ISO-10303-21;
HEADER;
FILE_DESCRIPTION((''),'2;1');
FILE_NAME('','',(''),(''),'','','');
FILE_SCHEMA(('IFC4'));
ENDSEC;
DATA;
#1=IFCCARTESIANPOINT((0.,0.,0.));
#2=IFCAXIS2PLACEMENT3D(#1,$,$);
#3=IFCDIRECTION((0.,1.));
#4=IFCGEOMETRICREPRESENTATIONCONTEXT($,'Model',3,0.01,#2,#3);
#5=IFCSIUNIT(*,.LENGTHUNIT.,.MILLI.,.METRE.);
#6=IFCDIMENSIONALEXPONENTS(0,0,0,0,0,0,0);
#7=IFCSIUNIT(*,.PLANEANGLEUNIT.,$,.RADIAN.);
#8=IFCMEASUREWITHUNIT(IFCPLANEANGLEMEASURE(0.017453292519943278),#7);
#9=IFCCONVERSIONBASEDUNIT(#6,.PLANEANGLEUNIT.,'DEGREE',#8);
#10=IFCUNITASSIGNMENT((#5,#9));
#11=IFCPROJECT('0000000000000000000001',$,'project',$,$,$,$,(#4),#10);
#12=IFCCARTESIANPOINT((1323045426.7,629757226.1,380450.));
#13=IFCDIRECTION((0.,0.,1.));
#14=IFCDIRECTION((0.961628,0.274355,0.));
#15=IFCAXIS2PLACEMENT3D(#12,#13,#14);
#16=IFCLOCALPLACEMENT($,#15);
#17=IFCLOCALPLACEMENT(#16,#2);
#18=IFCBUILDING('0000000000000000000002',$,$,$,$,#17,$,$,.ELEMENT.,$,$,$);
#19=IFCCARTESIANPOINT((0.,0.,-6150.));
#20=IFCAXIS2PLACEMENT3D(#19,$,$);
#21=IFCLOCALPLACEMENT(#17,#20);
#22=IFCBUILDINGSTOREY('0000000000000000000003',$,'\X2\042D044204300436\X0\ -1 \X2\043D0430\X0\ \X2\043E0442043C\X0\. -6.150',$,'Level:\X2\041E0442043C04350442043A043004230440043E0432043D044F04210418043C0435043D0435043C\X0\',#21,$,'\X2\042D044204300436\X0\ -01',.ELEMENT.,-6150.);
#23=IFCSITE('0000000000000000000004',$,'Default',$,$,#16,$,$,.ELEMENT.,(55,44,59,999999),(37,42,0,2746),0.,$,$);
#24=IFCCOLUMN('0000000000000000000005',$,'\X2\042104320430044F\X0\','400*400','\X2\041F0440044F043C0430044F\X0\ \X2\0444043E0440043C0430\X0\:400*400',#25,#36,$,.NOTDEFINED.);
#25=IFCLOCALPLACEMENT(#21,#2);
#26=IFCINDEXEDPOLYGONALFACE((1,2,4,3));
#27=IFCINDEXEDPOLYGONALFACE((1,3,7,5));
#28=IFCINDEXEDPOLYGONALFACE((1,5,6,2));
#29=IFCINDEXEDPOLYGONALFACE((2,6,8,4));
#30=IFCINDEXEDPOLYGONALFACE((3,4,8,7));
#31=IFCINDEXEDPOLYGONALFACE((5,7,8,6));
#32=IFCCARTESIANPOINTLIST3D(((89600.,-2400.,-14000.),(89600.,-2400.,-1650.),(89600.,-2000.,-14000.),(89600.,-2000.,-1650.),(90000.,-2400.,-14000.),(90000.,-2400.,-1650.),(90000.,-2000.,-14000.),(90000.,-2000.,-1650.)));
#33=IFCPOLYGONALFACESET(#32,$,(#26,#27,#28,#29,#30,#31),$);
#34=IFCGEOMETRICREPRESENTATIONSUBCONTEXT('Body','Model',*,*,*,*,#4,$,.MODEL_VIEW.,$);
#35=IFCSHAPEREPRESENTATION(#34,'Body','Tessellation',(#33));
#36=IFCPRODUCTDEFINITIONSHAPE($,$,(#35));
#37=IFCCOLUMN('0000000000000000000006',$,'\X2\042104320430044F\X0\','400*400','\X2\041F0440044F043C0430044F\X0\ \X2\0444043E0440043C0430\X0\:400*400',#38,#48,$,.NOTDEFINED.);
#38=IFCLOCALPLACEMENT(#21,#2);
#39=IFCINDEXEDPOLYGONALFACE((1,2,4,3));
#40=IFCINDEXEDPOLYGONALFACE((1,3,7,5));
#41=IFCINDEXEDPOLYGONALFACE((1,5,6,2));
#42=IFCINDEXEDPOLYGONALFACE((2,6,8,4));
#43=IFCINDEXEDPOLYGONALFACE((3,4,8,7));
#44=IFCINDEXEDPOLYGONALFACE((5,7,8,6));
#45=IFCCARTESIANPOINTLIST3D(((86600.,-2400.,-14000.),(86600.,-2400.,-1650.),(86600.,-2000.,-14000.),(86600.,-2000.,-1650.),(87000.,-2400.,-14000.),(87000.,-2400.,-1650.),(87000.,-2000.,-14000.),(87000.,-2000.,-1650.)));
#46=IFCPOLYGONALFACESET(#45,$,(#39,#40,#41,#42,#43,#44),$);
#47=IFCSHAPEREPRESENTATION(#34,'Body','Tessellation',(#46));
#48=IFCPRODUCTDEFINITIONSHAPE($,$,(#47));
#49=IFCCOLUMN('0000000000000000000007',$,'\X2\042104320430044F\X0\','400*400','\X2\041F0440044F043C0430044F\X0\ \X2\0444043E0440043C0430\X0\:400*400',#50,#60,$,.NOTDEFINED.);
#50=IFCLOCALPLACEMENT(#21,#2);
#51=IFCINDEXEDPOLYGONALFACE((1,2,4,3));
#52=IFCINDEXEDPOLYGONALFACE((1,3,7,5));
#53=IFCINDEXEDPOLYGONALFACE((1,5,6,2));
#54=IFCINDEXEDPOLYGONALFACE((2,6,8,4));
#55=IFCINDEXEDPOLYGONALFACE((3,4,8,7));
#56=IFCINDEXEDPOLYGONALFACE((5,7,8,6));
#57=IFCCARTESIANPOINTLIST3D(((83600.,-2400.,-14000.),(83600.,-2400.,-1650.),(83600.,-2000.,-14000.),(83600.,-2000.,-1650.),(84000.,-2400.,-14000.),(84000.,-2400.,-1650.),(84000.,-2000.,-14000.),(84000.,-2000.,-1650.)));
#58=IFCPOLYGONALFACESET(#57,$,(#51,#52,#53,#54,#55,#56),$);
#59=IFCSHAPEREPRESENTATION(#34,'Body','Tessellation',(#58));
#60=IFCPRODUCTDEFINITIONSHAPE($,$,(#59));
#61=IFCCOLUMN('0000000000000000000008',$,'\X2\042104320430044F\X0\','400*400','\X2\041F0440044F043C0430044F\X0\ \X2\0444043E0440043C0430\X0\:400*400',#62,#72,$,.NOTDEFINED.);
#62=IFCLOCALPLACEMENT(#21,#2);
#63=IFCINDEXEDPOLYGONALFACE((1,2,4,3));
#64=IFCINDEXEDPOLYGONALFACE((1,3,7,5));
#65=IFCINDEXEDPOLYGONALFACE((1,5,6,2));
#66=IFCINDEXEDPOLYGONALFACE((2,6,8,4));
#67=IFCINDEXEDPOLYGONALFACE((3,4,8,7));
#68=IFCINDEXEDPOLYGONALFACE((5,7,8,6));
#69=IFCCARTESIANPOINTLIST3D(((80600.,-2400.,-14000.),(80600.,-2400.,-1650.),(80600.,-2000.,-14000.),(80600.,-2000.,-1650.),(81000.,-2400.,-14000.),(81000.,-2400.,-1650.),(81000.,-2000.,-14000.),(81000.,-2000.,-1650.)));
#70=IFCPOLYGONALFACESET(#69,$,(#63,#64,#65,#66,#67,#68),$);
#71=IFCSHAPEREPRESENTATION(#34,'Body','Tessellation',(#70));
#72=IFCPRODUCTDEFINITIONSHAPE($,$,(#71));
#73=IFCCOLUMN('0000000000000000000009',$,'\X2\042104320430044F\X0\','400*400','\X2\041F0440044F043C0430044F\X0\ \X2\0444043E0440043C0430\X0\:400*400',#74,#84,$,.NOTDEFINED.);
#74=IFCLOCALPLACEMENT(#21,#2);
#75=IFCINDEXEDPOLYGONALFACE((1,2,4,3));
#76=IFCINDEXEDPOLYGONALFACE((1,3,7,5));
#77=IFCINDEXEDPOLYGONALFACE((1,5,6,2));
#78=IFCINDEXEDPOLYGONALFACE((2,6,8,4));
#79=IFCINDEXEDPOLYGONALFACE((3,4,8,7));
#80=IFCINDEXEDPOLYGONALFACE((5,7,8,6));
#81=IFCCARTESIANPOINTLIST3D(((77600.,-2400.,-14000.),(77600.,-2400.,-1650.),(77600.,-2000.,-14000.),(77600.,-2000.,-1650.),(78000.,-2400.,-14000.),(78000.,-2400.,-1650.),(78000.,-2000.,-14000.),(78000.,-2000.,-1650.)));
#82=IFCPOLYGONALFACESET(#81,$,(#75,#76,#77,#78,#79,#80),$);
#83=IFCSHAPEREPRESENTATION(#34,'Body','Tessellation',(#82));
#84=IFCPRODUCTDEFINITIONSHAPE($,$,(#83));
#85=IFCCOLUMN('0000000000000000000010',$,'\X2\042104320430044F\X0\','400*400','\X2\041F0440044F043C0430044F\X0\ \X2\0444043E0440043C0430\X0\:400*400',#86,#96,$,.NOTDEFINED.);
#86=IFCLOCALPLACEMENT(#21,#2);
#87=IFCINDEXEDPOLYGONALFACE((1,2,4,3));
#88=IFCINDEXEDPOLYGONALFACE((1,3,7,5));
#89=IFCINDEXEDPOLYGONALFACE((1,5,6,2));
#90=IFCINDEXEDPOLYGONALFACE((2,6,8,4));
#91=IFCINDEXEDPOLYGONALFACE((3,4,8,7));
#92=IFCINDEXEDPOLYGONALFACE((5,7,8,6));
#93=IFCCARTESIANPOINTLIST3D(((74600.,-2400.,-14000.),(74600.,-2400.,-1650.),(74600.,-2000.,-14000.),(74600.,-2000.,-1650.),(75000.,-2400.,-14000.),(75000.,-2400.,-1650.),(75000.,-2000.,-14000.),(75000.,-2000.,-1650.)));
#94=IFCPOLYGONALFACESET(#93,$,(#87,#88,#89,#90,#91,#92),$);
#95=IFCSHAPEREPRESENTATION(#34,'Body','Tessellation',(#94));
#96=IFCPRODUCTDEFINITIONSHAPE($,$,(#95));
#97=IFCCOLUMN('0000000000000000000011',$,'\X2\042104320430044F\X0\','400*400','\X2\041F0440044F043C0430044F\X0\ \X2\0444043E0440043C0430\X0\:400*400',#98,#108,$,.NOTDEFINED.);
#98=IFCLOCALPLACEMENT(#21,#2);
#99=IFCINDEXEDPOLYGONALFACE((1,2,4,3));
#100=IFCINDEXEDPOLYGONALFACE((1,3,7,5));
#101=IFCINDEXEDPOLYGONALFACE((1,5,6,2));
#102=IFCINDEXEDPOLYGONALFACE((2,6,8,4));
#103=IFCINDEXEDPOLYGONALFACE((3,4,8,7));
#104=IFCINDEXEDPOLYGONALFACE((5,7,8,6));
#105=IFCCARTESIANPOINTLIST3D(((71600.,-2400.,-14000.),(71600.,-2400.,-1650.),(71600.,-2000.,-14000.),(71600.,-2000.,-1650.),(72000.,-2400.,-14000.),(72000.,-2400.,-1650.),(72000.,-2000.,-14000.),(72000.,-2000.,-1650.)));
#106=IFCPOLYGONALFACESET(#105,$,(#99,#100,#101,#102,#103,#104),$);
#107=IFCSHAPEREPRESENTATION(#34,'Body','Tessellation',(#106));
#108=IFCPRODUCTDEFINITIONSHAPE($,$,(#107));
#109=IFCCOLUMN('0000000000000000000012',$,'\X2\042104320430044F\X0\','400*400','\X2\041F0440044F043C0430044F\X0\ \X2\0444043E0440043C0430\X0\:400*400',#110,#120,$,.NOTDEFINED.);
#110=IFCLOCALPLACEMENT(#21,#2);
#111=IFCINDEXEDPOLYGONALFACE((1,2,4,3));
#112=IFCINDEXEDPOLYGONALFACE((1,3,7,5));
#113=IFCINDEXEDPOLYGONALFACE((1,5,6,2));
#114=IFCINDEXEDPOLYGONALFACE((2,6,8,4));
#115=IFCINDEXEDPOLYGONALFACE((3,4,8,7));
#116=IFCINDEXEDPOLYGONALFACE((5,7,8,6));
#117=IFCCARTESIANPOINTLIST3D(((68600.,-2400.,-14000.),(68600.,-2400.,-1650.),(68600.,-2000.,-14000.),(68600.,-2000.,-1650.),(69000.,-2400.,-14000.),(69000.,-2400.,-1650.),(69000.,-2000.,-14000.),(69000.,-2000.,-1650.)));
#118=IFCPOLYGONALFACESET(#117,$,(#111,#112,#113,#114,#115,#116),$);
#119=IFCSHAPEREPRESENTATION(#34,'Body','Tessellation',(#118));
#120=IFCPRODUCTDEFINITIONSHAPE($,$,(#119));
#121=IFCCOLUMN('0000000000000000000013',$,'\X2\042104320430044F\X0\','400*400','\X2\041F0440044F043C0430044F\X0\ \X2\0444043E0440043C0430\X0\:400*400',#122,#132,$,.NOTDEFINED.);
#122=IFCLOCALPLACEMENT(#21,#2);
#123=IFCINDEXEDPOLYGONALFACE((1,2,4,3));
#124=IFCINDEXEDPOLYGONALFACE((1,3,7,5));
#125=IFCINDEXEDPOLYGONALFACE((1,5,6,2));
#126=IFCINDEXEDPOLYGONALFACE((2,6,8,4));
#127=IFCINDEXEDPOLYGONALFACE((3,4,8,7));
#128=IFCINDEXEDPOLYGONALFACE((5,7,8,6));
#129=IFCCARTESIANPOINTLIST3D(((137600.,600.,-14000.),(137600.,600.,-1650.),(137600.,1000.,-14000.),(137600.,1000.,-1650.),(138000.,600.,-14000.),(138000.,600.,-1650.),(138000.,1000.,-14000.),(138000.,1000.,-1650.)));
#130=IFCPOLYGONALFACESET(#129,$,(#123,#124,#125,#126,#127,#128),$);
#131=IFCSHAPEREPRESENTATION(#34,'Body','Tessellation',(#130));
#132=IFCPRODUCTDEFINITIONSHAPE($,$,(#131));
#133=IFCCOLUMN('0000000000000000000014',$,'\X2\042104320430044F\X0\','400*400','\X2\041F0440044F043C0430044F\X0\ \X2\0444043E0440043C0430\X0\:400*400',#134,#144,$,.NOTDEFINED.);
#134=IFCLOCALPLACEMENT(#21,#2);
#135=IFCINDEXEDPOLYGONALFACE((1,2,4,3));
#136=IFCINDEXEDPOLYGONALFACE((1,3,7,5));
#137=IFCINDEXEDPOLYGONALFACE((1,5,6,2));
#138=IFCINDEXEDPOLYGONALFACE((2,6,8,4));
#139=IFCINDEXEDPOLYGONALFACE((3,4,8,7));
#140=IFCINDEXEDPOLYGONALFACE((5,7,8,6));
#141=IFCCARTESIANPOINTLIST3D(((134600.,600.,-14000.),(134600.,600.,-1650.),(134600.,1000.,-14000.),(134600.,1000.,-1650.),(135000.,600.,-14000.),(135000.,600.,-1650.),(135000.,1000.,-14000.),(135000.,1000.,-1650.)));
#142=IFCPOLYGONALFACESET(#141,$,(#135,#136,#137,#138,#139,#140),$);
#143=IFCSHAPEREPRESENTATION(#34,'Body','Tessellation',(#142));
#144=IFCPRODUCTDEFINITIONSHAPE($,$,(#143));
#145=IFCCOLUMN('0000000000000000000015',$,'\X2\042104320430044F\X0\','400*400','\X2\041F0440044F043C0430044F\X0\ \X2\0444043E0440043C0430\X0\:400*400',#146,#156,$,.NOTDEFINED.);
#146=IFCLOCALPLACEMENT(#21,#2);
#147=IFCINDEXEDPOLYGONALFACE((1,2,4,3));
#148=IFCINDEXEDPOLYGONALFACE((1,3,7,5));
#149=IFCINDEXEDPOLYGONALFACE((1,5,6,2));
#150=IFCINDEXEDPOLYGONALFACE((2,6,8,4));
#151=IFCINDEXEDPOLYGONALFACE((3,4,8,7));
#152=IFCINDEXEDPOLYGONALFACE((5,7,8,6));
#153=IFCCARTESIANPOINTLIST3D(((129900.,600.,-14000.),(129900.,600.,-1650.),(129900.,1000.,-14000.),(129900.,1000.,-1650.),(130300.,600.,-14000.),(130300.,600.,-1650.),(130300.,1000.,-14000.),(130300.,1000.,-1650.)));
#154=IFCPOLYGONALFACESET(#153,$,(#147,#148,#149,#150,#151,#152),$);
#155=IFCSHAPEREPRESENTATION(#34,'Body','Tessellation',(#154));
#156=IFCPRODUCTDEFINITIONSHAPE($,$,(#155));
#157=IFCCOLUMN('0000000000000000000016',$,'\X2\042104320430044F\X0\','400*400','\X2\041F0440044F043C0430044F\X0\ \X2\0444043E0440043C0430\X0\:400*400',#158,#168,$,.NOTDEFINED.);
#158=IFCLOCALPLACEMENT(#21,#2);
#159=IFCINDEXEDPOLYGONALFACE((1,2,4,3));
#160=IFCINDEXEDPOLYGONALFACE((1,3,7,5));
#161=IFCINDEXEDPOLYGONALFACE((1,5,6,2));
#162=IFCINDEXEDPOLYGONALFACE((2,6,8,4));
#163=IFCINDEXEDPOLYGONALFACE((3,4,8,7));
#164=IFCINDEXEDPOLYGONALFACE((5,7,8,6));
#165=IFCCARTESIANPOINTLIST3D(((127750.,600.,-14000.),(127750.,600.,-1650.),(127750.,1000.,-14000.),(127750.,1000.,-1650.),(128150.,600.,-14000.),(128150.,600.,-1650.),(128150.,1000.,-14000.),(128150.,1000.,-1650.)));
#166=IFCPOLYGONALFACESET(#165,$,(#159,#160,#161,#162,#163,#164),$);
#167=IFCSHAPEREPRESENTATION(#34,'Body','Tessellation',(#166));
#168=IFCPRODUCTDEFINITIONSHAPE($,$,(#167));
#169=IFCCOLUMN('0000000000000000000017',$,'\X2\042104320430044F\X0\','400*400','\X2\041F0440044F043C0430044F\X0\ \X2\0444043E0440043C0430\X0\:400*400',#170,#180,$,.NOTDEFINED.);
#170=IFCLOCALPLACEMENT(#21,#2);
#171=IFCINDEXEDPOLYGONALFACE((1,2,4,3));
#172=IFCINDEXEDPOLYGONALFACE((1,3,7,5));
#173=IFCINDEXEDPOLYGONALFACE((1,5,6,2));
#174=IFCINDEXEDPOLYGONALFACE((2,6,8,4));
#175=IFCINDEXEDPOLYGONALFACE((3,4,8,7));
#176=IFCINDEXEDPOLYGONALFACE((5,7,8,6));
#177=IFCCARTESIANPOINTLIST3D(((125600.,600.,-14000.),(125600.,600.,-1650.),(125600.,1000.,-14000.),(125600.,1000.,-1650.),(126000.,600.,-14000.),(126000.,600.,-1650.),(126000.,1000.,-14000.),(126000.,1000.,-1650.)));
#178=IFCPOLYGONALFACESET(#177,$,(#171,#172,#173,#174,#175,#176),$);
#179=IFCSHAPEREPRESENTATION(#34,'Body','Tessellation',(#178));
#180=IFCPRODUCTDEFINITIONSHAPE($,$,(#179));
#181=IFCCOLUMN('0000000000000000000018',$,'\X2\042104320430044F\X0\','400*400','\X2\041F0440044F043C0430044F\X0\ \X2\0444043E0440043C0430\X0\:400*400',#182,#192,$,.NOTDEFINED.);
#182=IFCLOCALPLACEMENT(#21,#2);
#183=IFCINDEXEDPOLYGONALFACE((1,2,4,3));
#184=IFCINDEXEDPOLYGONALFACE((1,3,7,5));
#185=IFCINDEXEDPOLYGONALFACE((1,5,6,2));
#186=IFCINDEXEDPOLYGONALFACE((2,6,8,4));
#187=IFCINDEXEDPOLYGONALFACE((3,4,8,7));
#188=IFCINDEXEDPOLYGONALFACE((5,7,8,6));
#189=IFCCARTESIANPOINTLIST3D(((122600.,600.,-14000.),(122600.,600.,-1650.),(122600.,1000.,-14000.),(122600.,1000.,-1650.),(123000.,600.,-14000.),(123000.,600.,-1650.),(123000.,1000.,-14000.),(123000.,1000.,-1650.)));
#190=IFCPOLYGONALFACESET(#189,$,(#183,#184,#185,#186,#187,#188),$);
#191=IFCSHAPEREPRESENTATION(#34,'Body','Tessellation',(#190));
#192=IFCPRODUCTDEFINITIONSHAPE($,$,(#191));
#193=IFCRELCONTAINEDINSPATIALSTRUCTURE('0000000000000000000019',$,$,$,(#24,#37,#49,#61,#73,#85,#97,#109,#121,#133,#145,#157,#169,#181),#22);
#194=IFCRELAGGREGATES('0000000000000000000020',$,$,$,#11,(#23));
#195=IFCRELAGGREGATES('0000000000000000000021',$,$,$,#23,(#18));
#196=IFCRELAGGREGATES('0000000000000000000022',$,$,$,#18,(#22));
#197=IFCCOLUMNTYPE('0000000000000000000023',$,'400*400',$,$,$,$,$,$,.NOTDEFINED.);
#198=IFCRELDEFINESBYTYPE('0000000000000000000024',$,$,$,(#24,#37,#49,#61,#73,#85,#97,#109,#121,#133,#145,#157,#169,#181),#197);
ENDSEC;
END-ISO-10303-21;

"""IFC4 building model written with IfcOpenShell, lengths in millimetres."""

from ifc_helpers import new_model, entity, si_unit, converted_unit, direction, frame, origin, place, context, subcontext, project, spatial, indexed_curve, outline, extrude, type_object, element, save


model = new_model("IFC4")

# Units and contexts
model_context = context("Model", 3, precision=0.01, world=origin(), true_north=direction((0.0, 1.0)))
body_context = subcontext(model_context, "Body", "Model", "MODEL_VIEW")
ifc_project = project(units=[si_unit("LENGTHUNIT", "METRE", prefix="MILLI"), converted_unit("PLANEANGLEUNIT", "DEGREE", entity("IfcPlaneAngleMeasure", 0.017453292519943278), si_unit("PLANEANGLEUNIT", "RADIAN"), dimensions=[0, 0, 0, 0, 0, 0, 0])], contexts=[model_context])

# Site, building, storey
site_placement = place(None, frame((1323045426.7, 629757226.1, 380450.0), z_axis=(0.0, 0.0, 1.0), x_axis=(0.961628, 0.274355, 0.0)))
site = spatial("IfcSite", under=ifc_project, at=site_placement, Name="Default", CompositionType="ELEMENT", RefLatitude=(55, 44, 59, 999999), RefLongitude=(37, 42, 0, 2746), RefElevation=0.0)
building_placement = place(site_placement, origin())
building = spatial("IfcBuilding", under=site, at=building_placement, CompositionType="ELEMENT")
storey_placement = place(building_placement, frame((0.0, 0.0, -6150.0)))
storey = spatial("IfcBuildingStorey", under=building, at=storey_placement, Name="Этаж -1 на отм. -6.150", ObjectType="Level:ОтметкаУровняСИменем", LongName="Этаж -01", CompositionType="ELEMENT", Elevation=-6150.0)

# Columns
column_type = type_object("IfcColumnType", Name="400*400", PredefinedType="NOTDEFINED")
column_1_placement = place(storey_placement, origin())
element("IfcColumn", 1, at=column_1_placement, inside=storey, type_object=column_type, Name="Свая", Description="400*400", ObjectType="Прямая форма:400*400", PredefinedType="NOTDEFINED", context=body_context, shape_type="SweptSolid", body=[
    extrude(outline(indexed_curve([(-200.0, -200.0), (200.0, -200.0), (200.0, 200.0), (-200.0, 200.0), (-200.0, -200.0)], self_intersect=False)), frame((89800.0, -2200.0, -14000.0), z_axis=(0.0, 0.0, 1.0), x_axis=(0.0, 1.0, 0.0)), (0.0, 0.0, 1.0), 12350.0),
])
column_2_placement = place(storey_placement, origin())
element("IfcColumn", 2, at=column_2_placement, inside=storey, type_object=column_type, Name="Свая", Description="400*400", ObjectType="Прямая форма:400*400", PredefinedType="NOTDEFINED", context=body_context, shape_type="SweptSolid", body=[
    extrude(outline(indexed_curve([(-200.0, -200.0), (200.0, -200.0), (200.0, 200.0), (-200.0, 200.0), (-200.0, -200.0)], self_intersect=False)), frame((86800.0, -2200.0, -14000.0), z_axis=(0.0, 0.0, 1.0), x_axis=(0.0, 1.0, 0.0)), (0.0, 0.0, 1.0), 12350.0),
])
column_3_placement = place(storey_placement, origin())
element("IfcColumn", 3, at=column_3_placement, inside=storey, type_object=column_type, Name="Свая", Description="400*400", ObjectType="Прямая форма:400*400", PredefinedType="NOTDEFINED", context=body_context, shape_type="SweptSolid", body=[
    extrude(outline(indexed_curve([(-200.0, -200.0), (200.0, -200.0), (200.0, 200.0), (-200.0, 200.0), (-200.0, -200.0)], self_intersect=False)), frame((83800.0, -2200.0, -14000.0), z_axis=(0.0, 0.0, 1.0), x_axis=(0.0, 1.0, 0.0)), (0.0, 0.0, 1.0), 12350.0),
])
column_4_placement = place(storey_placement, origin())
element("IfcColumn", 4, at=column_4_placement, inside=storey, type_object=column_type, Name="Свая", Description="400*400", ObjectType="Прямая форма:400*400", PredefinedType="NOTDEFINED", context=body_context, shape_type="SweptSolid", body=[
    extrude(outline(indexed_curve([(-200.0, -200.0), (200.0, -200.0), (200.0, 200.0), (-200.0, 200.0), (-200.0, -200.0)], self_intersect=False)), frame((80800.0, -2200.0, -14000.0), z_axis=(0.0, 0.0, 1.0), x_axis=(0.0, 1.0, 0.0)), (0.0, 0.0, 1.0), 12350.0),
])
column_5_placement = place(storey_placement, origin())
element("IfcColumn", 5, at=column_5_placement, inside=storey, type_object=column_type, Name="Свая", Description="400*400", ObjectType="Прямая форма:400*400", PredefinedType="NOTDEFINED", context=body_context, shape_type="SweptSolid", body=[
    extrude(outline(indexed_curve([(-200.0, -200.0), (200.0, -200.0), (200.0, 200.0), (-200.0, 200.0), (-200.0, -200.0)], self_intersect=False)), frame((77800.0, -2200.0, -14000.0), z_axis=(0.0, 0.0, 1.0), x_axis=(0.0, 1.0, 0.0)), (0.0, 0.0, 1.0), 12350.0),
])
column_6_placement = place(storey_placement, origin())
element("IfcColumn", 6, at=column_6_placement, inside=storey, type_object=column_type, Name="Свая", Description="400*400", ObjectType="Прямая форма:400*400", PredefinedType="NOTDEFINED", context=body_context, shape_type="SweptSolid", body=[
    extrude(outline(indexed_curve([(-200.0, -200.0), (200.0, -200.0), (200.0, 200.0), (-200.0, 200.0), (-200.0, -200.0)], self_intersect=False)), frame((74800.0, -2200.0, -14000.0), z_axis=(0.0, 0.0, 1.0), x_axis=(0.0, 1.0, 0.0)), (0.0, 0.0, 1.0), 12350.0),
])
column_7_placement = place(storey_placement, origin())
element("IfcColumn", 7, at=column_7_placement, inside=storey, type_object=column_type, Name="Свая", Description="400*400", ObjectType="Прямая форма:400*400", PredefinedType="NOTDEFINED", context=body_context, shape_type="SweptSolid", body=[
    extrude(outline(indexed_curve([(-200.0, -200.0), (200.0, -200.0), (200.0, 200.0), (-200.0, 200.0), (-200.0, -200.0)], self_intersect=False)), frame((71800.0, -2200.0, -14000.0), z_axis=(0.0, 0.0, 1.0), x_axis=(0.0, 1.0, 0.0)), (0.0, 0.0, 1.0), 12350.0),
])
column_8_placement = place(storey_placement, origin())
element("IfcColumn", 8, at=column_8_placement, inside=storey, type_object=column_type, Name="Свая", Description="400*400", ObjectType="Прямая форма:400*400", PredefinedType="NOTDEFINED", context=body_context, shape_type="SweptSolid", body=[
    extrude(outline(indexed_curve([(-200.0, -200.0), (200.0, -200.0), (200.0, 200.0), (-200.0, 200.0), (-200.0, -200.0)], self_intersect=False)), frame((68800.0, -2200.0, -14000.0), z_axis=(0.0, 0.0, 1.0), x_axis=(0.0, 1.0, 0.0)), (0.0, 0.0, 1.0), 12350.0),
])
column_9_placement = place(storey_placement, origin())
element("IfcColumn", 9, at=column_9_placement, inside=storey, type_object=column_type, Name="Свая", Description="400*400", ObjectType="Прямая форма:400*400", PredefinedType="NOTDEFINED", context=body_context, shape_type="SweptSolid", body=[
    extrude(outline(indexed_curve([(-200.0, -200.0), (200.0, -200.0), (200.0, 200.0), (-200.0, 200.0), (-200.0, -200.0)], self_intersect=False)), frame((137800.0, 800.0, -14000.0), z_axis=(0.0, 0.0, 1.0), x_axis=(0.0, 1.0, 0.0)), (0.0, 0.0, 1.0), 12350.0),
])
column_10_placement = place(storey_placement, origin())
element("IfcColumn", 10, at=column_10_placement, inside=storey, type_object=column_type, Name="Свая", Description="400*400", ObjectType="Прямая форма:400*400", PredefinedType="NOTDEFINED", context=body_context, shape_type="SweptSolid", body=[
    extrude(outline(indexed_curve([(-200.0, -200.0), (200.0, -200.0), (200.0, 200.0), (-200.0, 200.0), (-200.0, -200.0)], self_intersect=False)), frame((134800.0, 800.0, -14000.0), z_axis=(0.0, 0.0, 1.0), x_axis=(0.0, 1.0, 0.0)), (0.0, 0.0, 1.0), 12350.0),
])
column_11_placement = place(storey_placement, origin())
element("IfcColumn", 11, at=column_11_placement, inside=storey, type_object=column_type, Name="Свая", Description="400*400", ObjectType="Прямая форма:400*400", PredefinedType="NOTDEFINED", context=body_context, shape_type="SweptSolid", body=[
    extrude(outline(indexed_curve([(-200.0, -200.0), (200.0, -200.0), (200.0, 200.0), (-200.0, 200.0), (-200.0, -200.0)], self_intersect=False)), frame((130100.0, 800.0, -14000.0), z_axis=(0.0, 0.0, 1.0), x_axis=(0.0, 1.0, 0.0)), (0.0, 0.0, 1.0), 12350.0),
])
column_12_placement = place(storey_placement, origin())
element("IfcColumn", 12, at=column_12_placement, inside=storey, type_object=column_type, Name="Свая", Description="400*400", ObjectType="Прямая форма:400*400", PredefinedType="NOTDEFINED", context=body_context, shape_type="SweptSolid", body=[
    extrude(outline(indexed_curve([(-200.0, -200.0), (200.0, -200.0), (200.0, 200.0), (-200.0, 200.0), (-200.0, -200.0)], self_intersect=False)), frame((127950.0, 800.0, -14000.0), z_axis=(0.0, 0.0, 1.0), x_axis=(0.0, 1.0, 0.0)), (0.0, 0.0, 1.0), 12350.0),
])
column_13_placement = place(storey_placement, origin())
element("IfcColumn", 13, at=column_13_placement, inside=storey, type_object=column_type, Name="Свая", Description="400*400", ObjectType="Прямая форма:400*400", PredefinedType="NOTDEFINED", context=body_context, shape_type="SweptSolid", body=[
    extrude(outline(indexed_curve([(-200.0, -200.0), (200.0, -200.0), (200.0, 200.0), (-200.0, 200.0), (-200.0, -200.0)], self_intersect=False)), frame((125800.0, 800.0, -14000.0), z_axis=(0.0, 0.0, 1.0), x_axis=(0.0, 1.0, 0.0)), (0.0, 0.0, 1.0), 12350.0),
])
column_14_placement = place(storey_placement, origin())
element("IfcColumn", 14, at=column_14_placement, inside=storey, type_object=column_type, Name="Свая", Description="400*400", ObjectType="Прямая форма:400*400", PredefinedType="NOTDEFINED", context=body_context, shape_type="SweptSolid", body=[
    extrude(outline(indexed_curve([(-200.0, -200.0), (200.0, -200.0), (200.0, 200.0), (-200.0, 200.0), (-200.0, -200.0)], self_intersect=False)), frame((122800.0, 800.0, -14000.0), z_axis=(0.0, 0.0, 1.0), x_axis=(0.0, 1.0, 0.0)), (0.0, 0.0, 1.0), 12350.0),
])

save(model, "model.ifc")
